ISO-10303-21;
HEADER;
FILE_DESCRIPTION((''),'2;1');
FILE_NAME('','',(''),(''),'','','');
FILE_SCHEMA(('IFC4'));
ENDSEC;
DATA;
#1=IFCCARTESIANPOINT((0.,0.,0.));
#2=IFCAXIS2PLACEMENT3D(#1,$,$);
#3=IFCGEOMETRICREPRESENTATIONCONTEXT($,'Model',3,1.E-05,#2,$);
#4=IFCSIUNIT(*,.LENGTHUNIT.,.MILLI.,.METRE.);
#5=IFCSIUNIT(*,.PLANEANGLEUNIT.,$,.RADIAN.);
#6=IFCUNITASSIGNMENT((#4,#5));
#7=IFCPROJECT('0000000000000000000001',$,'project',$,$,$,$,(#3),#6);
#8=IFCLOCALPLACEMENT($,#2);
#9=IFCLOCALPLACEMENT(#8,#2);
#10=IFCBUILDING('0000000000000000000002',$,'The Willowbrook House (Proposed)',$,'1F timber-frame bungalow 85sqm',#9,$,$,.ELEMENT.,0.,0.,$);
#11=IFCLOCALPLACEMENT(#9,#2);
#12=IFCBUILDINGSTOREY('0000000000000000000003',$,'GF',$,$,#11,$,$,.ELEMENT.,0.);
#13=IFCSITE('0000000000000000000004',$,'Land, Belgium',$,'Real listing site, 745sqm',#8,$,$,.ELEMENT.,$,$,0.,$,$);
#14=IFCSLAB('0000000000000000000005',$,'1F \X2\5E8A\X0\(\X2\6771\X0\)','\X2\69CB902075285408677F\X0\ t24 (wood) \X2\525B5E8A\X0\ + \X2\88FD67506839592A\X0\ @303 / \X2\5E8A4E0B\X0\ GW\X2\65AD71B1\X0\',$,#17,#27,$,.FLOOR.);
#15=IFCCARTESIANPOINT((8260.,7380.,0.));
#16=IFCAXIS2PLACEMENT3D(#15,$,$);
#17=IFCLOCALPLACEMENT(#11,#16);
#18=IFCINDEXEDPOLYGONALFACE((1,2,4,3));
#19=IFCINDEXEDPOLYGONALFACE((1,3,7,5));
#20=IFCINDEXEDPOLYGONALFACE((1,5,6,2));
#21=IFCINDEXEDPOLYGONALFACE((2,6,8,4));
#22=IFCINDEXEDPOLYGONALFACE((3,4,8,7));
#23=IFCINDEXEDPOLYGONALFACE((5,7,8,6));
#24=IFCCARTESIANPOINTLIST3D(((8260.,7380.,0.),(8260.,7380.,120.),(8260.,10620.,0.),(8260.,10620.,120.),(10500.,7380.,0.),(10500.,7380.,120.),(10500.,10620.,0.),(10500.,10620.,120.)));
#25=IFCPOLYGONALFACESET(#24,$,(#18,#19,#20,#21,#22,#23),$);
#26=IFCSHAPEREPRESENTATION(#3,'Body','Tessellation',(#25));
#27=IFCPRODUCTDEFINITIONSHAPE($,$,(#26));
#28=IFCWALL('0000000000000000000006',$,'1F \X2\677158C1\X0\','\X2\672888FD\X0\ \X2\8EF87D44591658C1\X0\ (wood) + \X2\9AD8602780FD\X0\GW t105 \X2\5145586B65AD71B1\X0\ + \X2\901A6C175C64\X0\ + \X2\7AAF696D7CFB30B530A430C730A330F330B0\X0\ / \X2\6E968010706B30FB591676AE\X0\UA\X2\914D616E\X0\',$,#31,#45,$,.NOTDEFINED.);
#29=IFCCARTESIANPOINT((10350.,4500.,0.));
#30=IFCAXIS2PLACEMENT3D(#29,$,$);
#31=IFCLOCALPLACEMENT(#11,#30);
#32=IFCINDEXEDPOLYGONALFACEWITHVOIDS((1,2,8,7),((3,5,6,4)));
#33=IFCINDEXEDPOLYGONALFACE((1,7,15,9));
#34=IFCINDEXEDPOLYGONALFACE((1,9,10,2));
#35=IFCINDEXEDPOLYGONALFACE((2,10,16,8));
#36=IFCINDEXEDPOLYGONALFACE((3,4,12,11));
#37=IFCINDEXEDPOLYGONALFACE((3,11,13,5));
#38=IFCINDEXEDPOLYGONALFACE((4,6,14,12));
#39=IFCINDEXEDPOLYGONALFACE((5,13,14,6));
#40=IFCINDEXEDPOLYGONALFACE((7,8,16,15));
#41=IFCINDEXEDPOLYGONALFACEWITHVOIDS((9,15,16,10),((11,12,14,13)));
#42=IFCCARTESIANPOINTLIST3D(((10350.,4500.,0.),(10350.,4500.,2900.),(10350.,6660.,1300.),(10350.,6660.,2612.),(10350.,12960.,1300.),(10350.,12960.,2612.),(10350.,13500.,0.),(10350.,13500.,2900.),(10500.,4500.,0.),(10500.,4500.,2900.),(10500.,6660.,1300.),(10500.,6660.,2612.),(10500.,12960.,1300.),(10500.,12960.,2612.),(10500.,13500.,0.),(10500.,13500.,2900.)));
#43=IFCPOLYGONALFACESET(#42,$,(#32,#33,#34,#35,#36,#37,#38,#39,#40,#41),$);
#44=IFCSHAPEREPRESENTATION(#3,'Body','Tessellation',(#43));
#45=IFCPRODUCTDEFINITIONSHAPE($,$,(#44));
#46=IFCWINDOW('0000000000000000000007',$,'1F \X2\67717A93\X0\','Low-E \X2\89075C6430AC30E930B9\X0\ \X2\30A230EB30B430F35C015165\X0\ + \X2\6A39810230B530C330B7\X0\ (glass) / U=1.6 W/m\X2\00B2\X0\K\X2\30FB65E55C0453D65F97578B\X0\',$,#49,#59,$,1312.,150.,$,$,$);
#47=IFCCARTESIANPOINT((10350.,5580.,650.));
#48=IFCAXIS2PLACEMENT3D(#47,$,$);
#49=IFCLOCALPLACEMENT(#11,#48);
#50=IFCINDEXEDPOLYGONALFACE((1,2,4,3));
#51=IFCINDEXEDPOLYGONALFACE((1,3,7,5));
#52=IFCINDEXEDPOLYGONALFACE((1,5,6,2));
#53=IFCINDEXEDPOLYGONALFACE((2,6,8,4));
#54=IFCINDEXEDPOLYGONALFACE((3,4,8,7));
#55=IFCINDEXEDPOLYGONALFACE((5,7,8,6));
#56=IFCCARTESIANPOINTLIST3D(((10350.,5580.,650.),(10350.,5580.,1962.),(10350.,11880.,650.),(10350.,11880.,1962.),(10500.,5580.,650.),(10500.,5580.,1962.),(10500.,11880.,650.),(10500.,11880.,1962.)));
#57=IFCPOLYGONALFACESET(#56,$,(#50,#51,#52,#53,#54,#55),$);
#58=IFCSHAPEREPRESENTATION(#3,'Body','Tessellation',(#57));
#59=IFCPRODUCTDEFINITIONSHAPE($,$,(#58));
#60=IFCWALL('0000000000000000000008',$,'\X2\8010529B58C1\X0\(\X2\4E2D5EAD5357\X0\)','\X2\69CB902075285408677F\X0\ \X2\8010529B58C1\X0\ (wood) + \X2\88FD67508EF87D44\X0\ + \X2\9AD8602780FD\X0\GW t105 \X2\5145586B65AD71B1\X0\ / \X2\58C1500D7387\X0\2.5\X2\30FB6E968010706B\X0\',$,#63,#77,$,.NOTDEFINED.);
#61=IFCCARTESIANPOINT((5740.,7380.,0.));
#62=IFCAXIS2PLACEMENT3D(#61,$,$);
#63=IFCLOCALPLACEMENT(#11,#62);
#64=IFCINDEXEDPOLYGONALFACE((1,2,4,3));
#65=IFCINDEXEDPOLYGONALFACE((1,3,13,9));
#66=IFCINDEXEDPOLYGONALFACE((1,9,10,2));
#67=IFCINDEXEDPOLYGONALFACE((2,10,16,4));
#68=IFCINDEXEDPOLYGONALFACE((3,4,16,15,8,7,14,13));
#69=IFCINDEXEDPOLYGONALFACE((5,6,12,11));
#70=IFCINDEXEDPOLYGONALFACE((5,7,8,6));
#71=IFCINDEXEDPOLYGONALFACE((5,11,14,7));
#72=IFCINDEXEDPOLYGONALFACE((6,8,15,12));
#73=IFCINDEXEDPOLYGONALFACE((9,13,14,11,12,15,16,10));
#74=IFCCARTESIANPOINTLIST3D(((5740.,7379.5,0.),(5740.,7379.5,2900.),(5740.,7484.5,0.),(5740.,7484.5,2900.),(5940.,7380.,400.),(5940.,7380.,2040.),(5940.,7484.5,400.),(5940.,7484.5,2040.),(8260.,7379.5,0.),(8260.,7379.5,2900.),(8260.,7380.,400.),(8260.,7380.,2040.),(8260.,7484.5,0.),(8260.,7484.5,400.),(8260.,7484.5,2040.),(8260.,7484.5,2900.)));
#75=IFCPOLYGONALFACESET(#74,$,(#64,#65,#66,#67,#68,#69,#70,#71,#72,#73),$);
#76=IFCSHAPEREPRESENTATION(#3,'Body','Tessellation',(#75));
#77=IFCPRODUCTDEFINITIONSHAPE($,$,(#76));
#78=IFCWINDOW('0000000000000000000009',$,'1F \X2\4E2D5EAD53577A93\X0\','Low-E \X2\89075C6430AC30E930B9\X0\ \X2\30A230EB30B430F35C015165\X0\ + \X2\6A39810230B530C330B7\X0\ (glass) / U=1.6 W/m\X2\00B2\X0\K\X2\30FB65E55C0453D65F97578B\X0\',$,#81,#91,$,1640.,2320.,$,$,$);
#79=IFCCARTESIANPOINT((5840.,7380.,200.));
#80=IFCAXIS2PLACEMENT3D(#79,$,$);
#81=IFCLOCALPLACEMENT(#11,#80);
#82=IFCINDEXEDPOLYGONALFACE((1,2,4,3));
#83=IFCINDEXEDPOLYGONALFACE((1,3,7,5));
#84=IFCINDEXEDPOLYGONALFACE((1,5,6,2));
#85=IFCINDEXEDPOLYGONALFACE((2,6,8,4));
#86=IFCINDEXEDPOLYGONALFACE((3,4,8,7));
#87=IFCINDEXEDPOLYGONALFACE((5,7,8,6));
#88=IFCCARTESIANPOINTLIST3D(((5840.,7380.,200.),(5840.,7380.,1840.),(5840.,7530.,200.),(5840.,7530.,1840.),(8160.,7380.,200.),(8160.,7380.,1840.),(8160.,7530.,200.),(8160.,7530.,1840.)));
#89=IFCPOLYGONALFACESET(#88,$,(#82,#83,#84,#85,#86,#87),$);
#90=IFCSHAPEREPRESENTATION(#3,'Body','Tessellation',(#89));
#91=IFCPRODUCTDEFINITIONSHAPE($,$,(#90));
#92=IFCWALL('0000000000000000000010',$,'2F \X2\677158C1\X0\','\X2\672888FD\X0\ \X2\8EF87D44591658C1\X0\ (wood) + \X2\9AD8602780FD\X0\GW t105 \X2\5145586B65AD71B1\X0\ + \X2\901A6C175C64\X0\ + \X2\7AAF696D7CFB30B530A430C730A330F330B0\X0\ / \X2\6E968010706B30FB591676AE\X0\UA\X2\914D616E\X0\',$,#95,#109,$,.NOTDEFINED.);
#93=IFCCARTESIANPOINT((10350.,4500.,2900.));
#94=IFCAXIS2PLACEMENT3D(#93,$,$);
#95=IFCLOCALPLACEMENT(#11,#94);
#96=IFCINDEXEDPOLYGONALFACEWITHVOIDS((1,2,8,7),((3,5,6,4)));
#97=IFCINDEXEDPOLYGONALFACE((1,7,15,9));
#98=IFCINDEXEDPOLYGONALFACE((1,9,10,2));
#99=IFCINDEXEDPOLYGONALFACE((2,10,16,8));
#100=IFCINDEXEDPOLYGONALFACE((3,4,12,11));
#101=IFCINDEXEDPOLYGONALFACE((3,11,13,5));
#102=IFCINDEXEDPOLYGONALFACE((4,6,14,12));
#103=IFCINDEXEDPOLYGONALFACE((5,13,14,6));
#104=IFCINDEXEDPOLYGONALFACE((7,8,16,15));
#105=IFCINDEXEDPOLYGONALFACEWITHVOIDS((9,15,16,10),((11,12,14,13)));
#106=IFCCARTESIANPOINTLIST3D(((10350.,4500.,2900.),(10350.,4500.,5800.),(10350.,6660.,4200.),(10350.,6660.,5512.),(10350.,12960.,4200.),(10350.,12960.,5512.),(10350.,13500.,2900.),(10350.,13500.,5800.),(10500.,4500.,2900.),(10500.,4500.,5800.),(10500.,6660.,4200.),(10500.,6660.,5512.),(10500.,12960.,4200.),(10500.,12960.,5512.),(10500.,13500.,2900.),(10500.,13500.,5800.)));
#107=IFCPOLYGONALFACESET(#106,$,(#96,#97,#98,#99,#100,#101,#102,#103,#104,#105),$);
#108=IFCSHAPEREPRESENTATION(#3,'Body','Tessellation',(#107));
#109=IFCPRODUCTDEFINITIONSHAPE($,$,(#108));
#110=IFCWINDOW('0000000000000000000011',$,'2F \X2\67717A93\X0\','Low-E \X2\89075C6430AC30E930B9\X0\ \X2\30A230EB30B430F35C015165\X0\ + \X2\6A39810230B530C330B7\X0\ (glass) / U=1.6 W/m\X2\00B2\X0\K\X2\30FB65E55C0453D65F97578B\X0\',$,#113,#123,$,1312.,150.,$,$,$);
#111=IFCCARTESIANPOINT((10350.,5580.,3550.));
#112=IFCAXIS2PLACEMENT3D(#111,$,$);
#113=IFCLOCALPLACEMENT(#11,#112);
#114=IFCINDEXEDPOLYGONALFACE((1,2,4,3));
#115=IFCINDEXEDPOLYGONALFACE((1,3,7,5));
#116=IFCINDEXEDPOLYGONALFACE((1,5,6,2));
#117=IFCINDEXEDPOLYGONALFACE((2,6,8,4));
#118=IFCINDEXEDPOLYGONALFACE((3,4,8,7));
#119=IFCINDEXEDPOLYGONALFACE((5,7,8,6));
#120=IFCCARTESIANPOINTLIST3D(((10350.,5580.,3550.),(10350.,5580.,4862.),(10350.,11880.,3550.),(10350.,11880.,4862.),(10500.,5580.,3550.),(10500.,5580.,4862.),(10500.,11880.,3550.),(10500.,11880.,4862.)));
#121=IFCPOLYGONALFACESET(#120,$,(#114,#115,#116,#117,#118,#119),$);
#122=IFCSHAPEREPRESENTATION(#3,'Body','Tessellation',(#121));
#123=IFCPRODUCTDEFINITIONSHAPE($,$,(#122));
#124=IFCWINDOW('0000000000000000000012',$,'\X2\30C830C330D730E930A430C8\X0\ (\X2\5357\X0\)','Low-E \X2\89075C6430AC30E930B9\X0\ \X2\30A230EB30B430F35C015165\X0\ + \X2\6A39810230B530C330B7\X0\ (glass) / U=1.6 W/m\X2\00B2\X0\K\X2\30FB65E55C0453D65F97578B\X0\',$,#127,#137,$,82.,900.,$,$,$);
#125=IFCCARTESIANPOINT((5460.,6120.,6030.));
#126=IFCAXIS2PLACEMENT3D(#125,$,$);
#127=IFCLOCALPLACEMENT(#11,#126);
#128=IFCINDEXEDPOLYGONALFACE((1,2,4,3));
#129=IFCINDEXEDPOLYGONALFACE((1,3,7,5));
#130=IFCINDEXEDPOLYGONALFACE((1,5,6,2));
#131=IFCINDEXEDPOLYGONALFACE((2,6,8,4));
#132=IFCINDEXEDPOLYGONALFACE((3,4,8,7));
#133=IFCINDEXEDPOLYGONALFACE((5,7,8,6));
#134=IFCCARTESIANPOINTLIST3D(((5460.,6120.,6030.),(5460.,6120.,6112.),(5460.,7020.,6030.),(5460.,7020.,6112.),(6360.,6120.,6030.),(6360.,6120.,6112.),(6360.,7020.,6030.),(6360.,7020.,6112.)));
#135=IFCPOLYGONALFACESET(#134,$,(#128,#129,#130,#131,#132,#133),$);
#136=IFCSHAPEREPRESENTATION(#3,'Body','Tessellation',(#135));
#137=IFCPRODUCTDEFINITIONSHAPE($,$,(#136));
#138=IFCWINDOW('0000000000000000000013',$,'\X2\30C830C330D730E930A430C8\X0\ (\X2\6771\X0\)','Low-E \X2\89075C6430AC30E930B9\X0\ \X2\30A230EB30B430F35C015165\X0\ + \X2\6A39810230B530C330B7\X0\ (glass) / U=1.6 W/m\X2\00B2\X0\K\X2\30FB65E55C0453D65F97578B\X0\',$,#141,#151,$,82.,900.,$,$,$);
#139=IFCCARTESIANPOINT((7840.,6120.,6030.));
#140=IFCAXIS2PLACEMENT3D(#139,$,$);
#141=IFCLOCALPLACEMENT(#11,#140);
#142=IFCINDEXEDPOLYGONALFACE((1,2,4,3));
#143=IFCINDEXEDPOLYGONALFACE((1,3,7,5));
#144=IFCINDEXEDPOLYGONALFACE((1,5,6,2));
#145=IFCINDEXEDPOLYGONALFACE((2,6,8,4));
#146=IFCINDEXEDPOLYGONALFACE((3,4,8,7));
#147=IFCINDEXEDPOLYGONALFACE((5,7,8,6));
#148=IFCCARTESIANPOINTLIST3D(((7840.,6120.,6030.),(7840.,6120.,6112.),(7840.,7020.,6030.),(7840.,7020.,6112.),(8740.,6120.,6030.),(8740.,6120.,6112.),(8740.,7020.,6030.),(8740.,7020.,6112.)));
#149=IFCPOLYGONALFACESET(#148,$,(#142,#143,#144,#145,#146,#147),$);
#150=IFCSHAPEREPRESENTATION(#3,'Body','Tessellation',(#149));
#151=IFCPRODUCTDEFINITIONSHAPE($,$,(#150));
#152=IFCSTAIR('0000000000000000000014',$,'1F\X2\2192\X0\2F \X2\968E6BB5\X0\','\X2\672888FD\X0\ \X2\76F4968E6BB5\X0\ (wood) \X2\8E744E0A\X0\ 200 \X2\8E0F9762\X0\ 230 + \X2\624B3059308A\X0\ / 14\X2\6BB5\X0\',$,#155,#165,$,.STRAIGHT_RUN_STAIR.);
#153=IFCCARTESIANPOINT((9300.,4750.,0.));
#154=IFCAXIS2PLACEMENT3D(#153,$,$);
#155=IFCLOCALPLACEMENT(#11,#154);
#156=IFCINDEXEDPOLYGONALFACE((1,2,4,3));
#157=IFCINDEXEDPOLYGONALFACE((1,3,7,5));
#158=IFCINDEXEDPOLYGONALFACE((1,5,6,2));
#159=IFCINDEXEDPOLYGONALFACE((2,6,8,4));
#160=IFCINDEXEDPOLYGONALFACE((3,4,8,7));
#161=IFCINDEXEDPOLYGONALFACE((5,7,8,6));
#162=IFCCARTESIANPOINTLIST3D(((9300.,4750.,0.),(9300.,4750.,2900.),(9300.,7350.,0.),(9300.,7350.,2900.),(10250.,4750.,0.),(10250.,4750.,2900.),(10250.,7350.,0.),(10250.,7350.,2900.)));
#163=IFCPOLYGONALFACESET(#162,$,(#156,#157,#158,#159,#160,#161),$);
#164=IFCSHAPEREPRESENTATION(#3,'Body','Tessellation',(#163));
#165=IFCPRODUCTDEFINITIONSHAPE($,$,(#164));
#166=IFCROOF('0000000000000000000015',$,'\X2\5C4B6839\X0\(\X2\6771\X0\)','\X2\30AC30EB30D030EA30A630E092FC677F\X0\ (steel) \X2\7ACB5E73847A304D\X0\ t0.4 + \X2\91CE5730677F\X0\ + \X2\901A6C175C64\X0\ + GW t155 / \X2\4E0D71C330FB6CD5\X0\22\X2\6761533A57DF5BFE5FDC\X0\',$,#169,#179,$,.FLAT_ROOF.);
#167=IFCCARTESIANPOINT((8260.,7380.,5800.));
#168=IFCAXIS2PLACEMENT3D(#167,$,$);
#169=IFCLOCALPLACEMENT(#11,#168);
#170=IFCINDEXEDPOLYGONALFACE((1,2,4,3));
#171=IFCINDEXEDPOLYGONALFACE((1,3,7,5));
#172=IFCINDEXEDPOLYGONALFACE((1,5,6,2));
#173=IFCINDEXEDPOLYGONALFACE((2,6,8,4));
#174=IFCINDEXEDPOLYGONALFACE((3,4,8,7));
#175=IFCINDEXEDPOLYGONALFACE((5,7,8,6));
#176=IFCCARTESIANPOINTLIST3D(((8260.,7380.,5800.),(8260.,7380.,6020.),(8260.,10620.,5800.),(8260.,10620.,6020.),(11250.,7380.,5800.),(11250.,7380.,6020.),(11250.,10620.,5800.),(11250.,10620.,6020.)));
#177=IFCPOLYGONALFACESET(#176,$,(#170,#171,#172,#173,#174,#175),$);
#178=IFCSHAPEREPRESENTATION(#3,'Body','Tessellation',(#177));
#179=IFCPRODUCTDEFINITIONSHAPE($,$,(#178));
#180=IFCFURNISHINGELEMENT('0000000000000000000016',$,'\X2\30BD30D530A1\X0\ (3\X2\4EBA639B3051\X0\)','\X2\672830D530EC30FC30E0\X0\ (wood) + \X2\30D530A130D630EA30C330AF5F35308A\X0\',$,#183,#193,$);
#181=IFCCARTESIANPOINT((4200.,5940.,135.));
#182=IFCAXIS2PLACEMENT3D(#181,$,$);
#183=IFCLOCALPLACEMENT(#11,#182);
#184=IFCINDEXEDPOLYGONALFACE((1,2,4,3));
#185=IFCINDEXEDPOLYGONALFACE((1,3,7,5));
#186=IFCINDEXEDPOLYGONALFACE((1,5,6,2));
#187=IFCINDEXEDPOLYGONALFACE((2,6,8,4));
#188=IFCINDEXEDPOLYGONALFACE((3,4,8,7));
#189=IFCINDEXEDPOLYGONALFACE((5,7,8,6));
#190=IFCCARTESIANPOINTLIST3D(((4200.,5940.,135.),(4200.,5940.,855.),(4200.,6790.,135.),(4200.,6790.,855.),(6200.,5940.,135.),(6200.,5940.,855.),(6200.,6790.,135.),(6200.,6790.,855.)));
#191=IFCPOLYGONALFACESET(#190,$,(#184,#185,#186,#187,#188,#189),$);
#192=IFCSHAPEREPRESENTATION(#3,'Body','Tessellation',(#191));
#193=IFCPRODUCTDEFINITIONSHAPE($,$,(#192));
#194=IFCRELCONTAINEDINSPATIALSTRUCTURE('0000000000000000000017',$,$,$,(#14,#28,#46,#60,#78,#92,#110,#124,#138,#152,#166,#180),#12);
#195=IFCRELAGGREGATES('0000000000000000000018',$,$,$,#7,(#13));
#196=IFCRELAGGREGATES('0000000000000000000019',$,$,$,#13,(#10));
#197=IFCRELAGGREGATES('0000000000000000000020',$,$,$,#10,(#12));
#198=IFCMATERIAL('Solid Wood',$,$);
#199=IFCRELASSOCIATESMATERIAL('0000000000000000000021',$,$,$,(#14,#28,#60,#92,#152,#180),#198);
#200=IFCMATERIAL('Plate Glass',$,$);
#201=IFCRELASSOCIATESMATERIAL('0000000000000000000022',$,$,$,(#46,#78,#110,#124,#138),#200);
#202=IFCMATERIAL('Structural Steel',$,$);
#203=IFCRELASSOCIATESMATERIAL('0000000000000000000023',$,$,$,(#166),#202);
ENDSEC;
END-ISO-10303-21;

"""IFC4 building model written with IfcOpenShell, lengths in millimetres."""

from ifc_helpers import new_model, si_unit, frame, frame_2d, origin, place, context, project, spatial, rectangle, extrude, material, element, fill, save


model = new_model("IFC4")

# Units and contexts
model_context = context("Model", 3, precision=1e-05, world=origin())
ifc_project = project(units=[si_unit("LENGTHUNIT", "METRE", prefix="MILLI"), si_unit("PLANEANGLEUNIT", "RADIAN")], contexts=[model_context])

# Site, building, storey
site_placement = place(None, origin())
site = spatial("IfcSite", under=ifc_project, at=site_placement, Name="Land, Belgium", ObjectType="Real listing site, 745sqm", CompositionType="ELEMENT", RefElevation=0.0)
building_placement = place(site_placement, origin())
building = spatial("IfcBuilding", under=site, at=building_placement, Name="The Willowbrook House (Proposed)", ObjectType="1F timber-frame bungalow 85sqm", CompositionType="ELEMENT", ElevationOfRefHeight=0.0, ElevationOfTerrain=0.0)
storey_placement = place(building_placement, origin())
storey = spatial("IfcBuildingStorey", under=building, at=storey_placement, Name="GF", CompositionType="ELEMENT", Elevation=0.0)

# Slab
ifc_material_1 = material(Name="Solid Wood")
slab_placement = place(storey_placement, frame((8260.0, 7380.0, 0.0)))
element("IfcSlab", 1, at=slab_placement, inside=storey, material=ifc_material_1, Name="1F 床(東)", Description="構造用合板 t24 (wood) 剛床 + 製材根太 @303 / 床下 GW断熱", PredefinedType="FLOOR", context=model_context, shape_type="SweptSolid", body=[
    extrude(rectangle(XDim=2240.0, YDim=3240.0, at=frame_2d((1120.0, 1620.0))), frame((8260.0, 7380.0, 0.0)), (0.0, 0.0, 1.0), 120.0),
])

# Walls, openings, windows
wall_1_placement = place(storey_placement, frame((10350.0, 4500.0, 0.0)))
wall_1 = element("IfcWall", 2, at=wall_1_placement, inside=storey, material=ifc_material_1, Name="1F 東壁", Description="木製 軸組外壁 (wood) + 高性能GW t105 充填断熱 + 通気層 + 窯業系サイディング / 準耐火・外皮UA配慮", PredefinedType="NOTDEFINED", context=model_context, shape_type="SweptSolid", body=[
    extrude(rectangle(XDim=150.0, YDim=9000.0, at=frame_2d((75.0, 4500.0))), frame((10350.0, 4500.0, 0.0)), (0.0, 0.0, 1.0), 2900.0),
])
opening_1_placement = place(storey_placement, frame((10350.0, 5580.0, 650.0)))
opening_1 = element("IfcOpeningElement", 3, at=opening_1_placement, cuts=wall_1, PredefinedType="NOTDEFINED", context=model_context, shape_type="SweptSolid", body=[
    extrude(rectangle(XDim=150.0, YDim=6300.0, at=frame_2d((75.0, 3150.0))), frame((10350.0, 5580.0, 650.0)), (0.0, 0.0, 1.0), 1312.0),
])
ifc_material_2 = material(Name="Plate Glass")
window_1_placement = place(storey_placement, frame((10350.0, 5580.0, 650.0)))
window_1 = element("IfcWindow", 4, at=window_1_placement, inside=storey, material=ifc_material_2, Name="1F 東窓", Description="Low-E 複層ガラス アルゴン封入 + 樹脂サッシ (glass) / U=1.6 W/m²K・日射取得型", OverallHeight=1312.0, OverallWidth=150.0, context=model_context, shape_type="SweptSolid", body=[
    extrude(rectangle(XDim=150.0, YDim=6300.0, at=frame_2d((75.0, 3150.0))), frame((10350.0, 5580.0, 650.0)), (0.0, 0.0, 1.0), 1312.0),
])
fill(opening_1, window_1)
wall_2_placement = place(storey_placement, frame((5740.0, 7380.0, 0.0)))
wall_2 = element("IfcWall", 5, at=wall_2_placement, inside=storey, material=ifc_material_1, Name="耐力壁(中庭南)", Description="構造用合板 耐力壁 (wood) + 製材軸組 + 高性能GW t105 充填断熱 / 壁倍率2.5・準耐火", PredefinedType="NOTDEFINED", context=model_context, shape_type="SweptSolid", body=[
    extrude(rectangle(XDim=2520.0, YDim=105.0, at=frame_2d((1260.0, 52.0))), frame((5740.0, 7380.0, 0.0)), (0.0, 0.0, 1.0), 2900.0),
])
opening_2_placement = place(storey_placement, frame((5840.0, 7380.0, 200.0)))
opening_2 = element("IfcOpeningElement", 6, at=opening_2_placement, cuts=wall_2, PredefinedType="NOTDEFINED", context=model_context, shape_type="SweptSolid", body=[
    extrude(rectangle(XDim=2320.0, YDim=150.0, at=frame_2d((1160.0, 75.0))), frame((5840.0, 7380.0, 200.0)), (0.0, 0.0, 1.0), 1640.0),
])
window_2_placement = place(storey_placement, frame((5840.0, 7380.0, 200.0)))
window_2 = element("IfcWindow", 7, at=window_2_placement, inside=storey, material=ifc_material_2, Name="1F 中庭南窓", Description="Low-E 複層ガラス アルゴン封入 + 樹脂サッシ (glass) / U=1.6 W/m²K・日射取得型", OverallHeight=1640.0, OverallWidth=2320.0, context=model_context, shape_type="SweptSolid", body=[
    extrude(rectangle(XDim=2320.0, YDim=150.0, at=frame_2d((1160.0, 75.0))), frame((5840.0, 7380.0, 200.0)), (0.0, 0.0, 1.0), 1640.0),
])
fill(opening_2, window_2)

# Wall, opening, window
wall_3_placement = place(storey_placement, frame((10350.0, 4500.0, 2900.0)))
wall_3 = element("IfcWall", 8, at=wall_3_placement, inside=storey, material=ifc_material_1, Name="2F 東壁", Description="木製 軸組外壁 (wood) + 高性能GW t105 充填断熱 + 通気層 + 窯業系サイディング / 準耐火・外皮UA配慮", PredefinedType="NOTDEFINED", context=model_context, shape_type="SweptSolid", body=[
    extrude(rectangle(XDim=150.0, YDim=9000.0, at=frame_2d((75.0, 4500.0))), frame((10350.0, 4500.0, 2900.0)), (0.0, 0.0, 1.0), 2900.0),
])
opening_3_placement = place(storey_placement, frame((10350.0, 5580.0, 3550.0)))
opening_3 = element("IfcOpeningElement", 9, at=opening_3_placement, cuts=wall_3, PredefinedType="NOTDEFINED", context=model_context, shape_type="SweptSolid", body=[
    extrude(rectangle(XDim=150.0, YDim=6300.0, at=frame_2d((75.0, 3150.0))), frame((10350.0, 5580.0, 3550.0)), (0.0, 0.0, 1.0), 1312.0),
])
window_3_placement = place(storey_placement, frame((10350.0, 5580.0, 3550.0)))
window_3 = element("IfcWindow", 10, at=window_3_placement, inside=storey, material=ifc_material_2, Name="2F 東窓", Description="Low-E 複層ガラス アルゴン封入 + 樹脂サッシ (glass) / U=1.6 W/m²K・日射取得型", OverallHeight=1312.0, OverallWidth=150.0, context=model_context, shape_type="SweptSolid", body=[
    extrude(rectangle(XDim=150.0, YDim=6300.0, at=frame_2d((75.0, 3150.0))), frame((10350.0, 5580.0, 3550.0)), (0.0, 0.0, 1.0), 1312.0),
])
fill(opening_3, window_3)

# Windows
window_4_placement = place(storey_placement, frame((5460.0, 6120.0, 6030.0)))
element("IfcWindow", 11, at=window_4_placement, inside=storey, material=ifc_material_2, Name="トップライト (南)", Description="Low-E 複層ガラス アルゴン封入 + 樹脂サッシ (glass) / U=1.6 W/m²K・日射取得型", OverallHeight=82.0, OverallWidth=900.0, context=model_context, shape_type="SweptSolid", body=[
    extrude(rectangle(XDim=900.0, YDim=900.0, at=frame_2d((450.0, 450.0))), frame((5460.0, 6120.0, 6030.0)), (0.0, 0.0, 1.0), 82.0),
])
window_5_placement = place(storey_placement, frame((7840.0, 6120.0, 6030.0)))
element("IfcWindow", 12, at=window_5_placement, inside=storey, material=ifc_material_2, Name="トップライト (東)", Description="Low-E 複層ガラス アルゴン封入 + 樹脂サッシ (glass) / U=1.6 W/m²K・日射取得型", OverallHeight=82.0, OverallWidth=900.0, context=model_context, shape_type="SweptSolid", body=[
    extrude(rectangle(XDim=900.0, YDim=900.0, at=frame_2d((450.0, 450.0))), frame((7840.0, 6120.0, 6030.0)), (0.0, 0.0, 1.0), 82.0),
])

# Stair
stair_placement = place(storey_placement, frame((9300.0, 4750.0, 0.0)))
element("IfcStair", 13, at=stair_placement, inside=storey, material=ifc_material_1, Name="1F→2F 階段", Description="木製 直階段 (wood) 蹴上 200 踏面 230 + 手すり / 14段", PredefinedType="STRAIGHT_RUN_STAIR", context=model_context, shape_type="SweptSolid", body=[
    extrude(rectangle(XDim=950.0, YDim=2600.0, at=frame_2d((475.0, 1300.0))), frame((9300.0, 4750.0, 0.0)), (0.0, 0.0, 1.0), 2900.0),
])

# Roof
ifc_material_3 = material(Name="Structural Steel")
roof_placement = place(storey_placement, frame((8260.0, 7380.0, 5800.0)))
element("IfcRoof", 14, at=roof_placement, inside=storey, material=ifc_material_3, Name="屋根(東)", Description="ガルバリウム鋼板 (steel) 立平葺き t0.4 + 野地板 + 通気層 + GW t155 / 不燃・法22条区域対応", PredefinedType="FLAT_ROOF", context=model_context, shape_type="SweptSolid", body=[
    extrude(rectangle(XDim=2990.0, YDim=3240.0, at=frame_2d((1495.0, 1620.0))), frame((8260.0, 7380.0, 5800.0)), (0.0, 0.0, 1.0), 220.0),
])

# Furnishing element
furnishing_1_placement = place(storey_placement, frame((4200.0, 5940.0, 135.0)))
element("IfcFurnishingElement", 15, at=furnishing_1_placement, inside=storey, material=ifc_material_1, Name="ソファ (3人掛け)", Description="木フレーム (wood) + ファブリック張り", context=model_context, shape_type="SweptSolid", body=[
    extrude(rectangle(XDim=2000.0, YDim=850.0, at=frame_2d((1000.0, 425.0))), frame((4200.0, 5940.0, 135.0)), (0.0, 0.0, 1.0), 720.0),
])

save(model, "model.ifc")
